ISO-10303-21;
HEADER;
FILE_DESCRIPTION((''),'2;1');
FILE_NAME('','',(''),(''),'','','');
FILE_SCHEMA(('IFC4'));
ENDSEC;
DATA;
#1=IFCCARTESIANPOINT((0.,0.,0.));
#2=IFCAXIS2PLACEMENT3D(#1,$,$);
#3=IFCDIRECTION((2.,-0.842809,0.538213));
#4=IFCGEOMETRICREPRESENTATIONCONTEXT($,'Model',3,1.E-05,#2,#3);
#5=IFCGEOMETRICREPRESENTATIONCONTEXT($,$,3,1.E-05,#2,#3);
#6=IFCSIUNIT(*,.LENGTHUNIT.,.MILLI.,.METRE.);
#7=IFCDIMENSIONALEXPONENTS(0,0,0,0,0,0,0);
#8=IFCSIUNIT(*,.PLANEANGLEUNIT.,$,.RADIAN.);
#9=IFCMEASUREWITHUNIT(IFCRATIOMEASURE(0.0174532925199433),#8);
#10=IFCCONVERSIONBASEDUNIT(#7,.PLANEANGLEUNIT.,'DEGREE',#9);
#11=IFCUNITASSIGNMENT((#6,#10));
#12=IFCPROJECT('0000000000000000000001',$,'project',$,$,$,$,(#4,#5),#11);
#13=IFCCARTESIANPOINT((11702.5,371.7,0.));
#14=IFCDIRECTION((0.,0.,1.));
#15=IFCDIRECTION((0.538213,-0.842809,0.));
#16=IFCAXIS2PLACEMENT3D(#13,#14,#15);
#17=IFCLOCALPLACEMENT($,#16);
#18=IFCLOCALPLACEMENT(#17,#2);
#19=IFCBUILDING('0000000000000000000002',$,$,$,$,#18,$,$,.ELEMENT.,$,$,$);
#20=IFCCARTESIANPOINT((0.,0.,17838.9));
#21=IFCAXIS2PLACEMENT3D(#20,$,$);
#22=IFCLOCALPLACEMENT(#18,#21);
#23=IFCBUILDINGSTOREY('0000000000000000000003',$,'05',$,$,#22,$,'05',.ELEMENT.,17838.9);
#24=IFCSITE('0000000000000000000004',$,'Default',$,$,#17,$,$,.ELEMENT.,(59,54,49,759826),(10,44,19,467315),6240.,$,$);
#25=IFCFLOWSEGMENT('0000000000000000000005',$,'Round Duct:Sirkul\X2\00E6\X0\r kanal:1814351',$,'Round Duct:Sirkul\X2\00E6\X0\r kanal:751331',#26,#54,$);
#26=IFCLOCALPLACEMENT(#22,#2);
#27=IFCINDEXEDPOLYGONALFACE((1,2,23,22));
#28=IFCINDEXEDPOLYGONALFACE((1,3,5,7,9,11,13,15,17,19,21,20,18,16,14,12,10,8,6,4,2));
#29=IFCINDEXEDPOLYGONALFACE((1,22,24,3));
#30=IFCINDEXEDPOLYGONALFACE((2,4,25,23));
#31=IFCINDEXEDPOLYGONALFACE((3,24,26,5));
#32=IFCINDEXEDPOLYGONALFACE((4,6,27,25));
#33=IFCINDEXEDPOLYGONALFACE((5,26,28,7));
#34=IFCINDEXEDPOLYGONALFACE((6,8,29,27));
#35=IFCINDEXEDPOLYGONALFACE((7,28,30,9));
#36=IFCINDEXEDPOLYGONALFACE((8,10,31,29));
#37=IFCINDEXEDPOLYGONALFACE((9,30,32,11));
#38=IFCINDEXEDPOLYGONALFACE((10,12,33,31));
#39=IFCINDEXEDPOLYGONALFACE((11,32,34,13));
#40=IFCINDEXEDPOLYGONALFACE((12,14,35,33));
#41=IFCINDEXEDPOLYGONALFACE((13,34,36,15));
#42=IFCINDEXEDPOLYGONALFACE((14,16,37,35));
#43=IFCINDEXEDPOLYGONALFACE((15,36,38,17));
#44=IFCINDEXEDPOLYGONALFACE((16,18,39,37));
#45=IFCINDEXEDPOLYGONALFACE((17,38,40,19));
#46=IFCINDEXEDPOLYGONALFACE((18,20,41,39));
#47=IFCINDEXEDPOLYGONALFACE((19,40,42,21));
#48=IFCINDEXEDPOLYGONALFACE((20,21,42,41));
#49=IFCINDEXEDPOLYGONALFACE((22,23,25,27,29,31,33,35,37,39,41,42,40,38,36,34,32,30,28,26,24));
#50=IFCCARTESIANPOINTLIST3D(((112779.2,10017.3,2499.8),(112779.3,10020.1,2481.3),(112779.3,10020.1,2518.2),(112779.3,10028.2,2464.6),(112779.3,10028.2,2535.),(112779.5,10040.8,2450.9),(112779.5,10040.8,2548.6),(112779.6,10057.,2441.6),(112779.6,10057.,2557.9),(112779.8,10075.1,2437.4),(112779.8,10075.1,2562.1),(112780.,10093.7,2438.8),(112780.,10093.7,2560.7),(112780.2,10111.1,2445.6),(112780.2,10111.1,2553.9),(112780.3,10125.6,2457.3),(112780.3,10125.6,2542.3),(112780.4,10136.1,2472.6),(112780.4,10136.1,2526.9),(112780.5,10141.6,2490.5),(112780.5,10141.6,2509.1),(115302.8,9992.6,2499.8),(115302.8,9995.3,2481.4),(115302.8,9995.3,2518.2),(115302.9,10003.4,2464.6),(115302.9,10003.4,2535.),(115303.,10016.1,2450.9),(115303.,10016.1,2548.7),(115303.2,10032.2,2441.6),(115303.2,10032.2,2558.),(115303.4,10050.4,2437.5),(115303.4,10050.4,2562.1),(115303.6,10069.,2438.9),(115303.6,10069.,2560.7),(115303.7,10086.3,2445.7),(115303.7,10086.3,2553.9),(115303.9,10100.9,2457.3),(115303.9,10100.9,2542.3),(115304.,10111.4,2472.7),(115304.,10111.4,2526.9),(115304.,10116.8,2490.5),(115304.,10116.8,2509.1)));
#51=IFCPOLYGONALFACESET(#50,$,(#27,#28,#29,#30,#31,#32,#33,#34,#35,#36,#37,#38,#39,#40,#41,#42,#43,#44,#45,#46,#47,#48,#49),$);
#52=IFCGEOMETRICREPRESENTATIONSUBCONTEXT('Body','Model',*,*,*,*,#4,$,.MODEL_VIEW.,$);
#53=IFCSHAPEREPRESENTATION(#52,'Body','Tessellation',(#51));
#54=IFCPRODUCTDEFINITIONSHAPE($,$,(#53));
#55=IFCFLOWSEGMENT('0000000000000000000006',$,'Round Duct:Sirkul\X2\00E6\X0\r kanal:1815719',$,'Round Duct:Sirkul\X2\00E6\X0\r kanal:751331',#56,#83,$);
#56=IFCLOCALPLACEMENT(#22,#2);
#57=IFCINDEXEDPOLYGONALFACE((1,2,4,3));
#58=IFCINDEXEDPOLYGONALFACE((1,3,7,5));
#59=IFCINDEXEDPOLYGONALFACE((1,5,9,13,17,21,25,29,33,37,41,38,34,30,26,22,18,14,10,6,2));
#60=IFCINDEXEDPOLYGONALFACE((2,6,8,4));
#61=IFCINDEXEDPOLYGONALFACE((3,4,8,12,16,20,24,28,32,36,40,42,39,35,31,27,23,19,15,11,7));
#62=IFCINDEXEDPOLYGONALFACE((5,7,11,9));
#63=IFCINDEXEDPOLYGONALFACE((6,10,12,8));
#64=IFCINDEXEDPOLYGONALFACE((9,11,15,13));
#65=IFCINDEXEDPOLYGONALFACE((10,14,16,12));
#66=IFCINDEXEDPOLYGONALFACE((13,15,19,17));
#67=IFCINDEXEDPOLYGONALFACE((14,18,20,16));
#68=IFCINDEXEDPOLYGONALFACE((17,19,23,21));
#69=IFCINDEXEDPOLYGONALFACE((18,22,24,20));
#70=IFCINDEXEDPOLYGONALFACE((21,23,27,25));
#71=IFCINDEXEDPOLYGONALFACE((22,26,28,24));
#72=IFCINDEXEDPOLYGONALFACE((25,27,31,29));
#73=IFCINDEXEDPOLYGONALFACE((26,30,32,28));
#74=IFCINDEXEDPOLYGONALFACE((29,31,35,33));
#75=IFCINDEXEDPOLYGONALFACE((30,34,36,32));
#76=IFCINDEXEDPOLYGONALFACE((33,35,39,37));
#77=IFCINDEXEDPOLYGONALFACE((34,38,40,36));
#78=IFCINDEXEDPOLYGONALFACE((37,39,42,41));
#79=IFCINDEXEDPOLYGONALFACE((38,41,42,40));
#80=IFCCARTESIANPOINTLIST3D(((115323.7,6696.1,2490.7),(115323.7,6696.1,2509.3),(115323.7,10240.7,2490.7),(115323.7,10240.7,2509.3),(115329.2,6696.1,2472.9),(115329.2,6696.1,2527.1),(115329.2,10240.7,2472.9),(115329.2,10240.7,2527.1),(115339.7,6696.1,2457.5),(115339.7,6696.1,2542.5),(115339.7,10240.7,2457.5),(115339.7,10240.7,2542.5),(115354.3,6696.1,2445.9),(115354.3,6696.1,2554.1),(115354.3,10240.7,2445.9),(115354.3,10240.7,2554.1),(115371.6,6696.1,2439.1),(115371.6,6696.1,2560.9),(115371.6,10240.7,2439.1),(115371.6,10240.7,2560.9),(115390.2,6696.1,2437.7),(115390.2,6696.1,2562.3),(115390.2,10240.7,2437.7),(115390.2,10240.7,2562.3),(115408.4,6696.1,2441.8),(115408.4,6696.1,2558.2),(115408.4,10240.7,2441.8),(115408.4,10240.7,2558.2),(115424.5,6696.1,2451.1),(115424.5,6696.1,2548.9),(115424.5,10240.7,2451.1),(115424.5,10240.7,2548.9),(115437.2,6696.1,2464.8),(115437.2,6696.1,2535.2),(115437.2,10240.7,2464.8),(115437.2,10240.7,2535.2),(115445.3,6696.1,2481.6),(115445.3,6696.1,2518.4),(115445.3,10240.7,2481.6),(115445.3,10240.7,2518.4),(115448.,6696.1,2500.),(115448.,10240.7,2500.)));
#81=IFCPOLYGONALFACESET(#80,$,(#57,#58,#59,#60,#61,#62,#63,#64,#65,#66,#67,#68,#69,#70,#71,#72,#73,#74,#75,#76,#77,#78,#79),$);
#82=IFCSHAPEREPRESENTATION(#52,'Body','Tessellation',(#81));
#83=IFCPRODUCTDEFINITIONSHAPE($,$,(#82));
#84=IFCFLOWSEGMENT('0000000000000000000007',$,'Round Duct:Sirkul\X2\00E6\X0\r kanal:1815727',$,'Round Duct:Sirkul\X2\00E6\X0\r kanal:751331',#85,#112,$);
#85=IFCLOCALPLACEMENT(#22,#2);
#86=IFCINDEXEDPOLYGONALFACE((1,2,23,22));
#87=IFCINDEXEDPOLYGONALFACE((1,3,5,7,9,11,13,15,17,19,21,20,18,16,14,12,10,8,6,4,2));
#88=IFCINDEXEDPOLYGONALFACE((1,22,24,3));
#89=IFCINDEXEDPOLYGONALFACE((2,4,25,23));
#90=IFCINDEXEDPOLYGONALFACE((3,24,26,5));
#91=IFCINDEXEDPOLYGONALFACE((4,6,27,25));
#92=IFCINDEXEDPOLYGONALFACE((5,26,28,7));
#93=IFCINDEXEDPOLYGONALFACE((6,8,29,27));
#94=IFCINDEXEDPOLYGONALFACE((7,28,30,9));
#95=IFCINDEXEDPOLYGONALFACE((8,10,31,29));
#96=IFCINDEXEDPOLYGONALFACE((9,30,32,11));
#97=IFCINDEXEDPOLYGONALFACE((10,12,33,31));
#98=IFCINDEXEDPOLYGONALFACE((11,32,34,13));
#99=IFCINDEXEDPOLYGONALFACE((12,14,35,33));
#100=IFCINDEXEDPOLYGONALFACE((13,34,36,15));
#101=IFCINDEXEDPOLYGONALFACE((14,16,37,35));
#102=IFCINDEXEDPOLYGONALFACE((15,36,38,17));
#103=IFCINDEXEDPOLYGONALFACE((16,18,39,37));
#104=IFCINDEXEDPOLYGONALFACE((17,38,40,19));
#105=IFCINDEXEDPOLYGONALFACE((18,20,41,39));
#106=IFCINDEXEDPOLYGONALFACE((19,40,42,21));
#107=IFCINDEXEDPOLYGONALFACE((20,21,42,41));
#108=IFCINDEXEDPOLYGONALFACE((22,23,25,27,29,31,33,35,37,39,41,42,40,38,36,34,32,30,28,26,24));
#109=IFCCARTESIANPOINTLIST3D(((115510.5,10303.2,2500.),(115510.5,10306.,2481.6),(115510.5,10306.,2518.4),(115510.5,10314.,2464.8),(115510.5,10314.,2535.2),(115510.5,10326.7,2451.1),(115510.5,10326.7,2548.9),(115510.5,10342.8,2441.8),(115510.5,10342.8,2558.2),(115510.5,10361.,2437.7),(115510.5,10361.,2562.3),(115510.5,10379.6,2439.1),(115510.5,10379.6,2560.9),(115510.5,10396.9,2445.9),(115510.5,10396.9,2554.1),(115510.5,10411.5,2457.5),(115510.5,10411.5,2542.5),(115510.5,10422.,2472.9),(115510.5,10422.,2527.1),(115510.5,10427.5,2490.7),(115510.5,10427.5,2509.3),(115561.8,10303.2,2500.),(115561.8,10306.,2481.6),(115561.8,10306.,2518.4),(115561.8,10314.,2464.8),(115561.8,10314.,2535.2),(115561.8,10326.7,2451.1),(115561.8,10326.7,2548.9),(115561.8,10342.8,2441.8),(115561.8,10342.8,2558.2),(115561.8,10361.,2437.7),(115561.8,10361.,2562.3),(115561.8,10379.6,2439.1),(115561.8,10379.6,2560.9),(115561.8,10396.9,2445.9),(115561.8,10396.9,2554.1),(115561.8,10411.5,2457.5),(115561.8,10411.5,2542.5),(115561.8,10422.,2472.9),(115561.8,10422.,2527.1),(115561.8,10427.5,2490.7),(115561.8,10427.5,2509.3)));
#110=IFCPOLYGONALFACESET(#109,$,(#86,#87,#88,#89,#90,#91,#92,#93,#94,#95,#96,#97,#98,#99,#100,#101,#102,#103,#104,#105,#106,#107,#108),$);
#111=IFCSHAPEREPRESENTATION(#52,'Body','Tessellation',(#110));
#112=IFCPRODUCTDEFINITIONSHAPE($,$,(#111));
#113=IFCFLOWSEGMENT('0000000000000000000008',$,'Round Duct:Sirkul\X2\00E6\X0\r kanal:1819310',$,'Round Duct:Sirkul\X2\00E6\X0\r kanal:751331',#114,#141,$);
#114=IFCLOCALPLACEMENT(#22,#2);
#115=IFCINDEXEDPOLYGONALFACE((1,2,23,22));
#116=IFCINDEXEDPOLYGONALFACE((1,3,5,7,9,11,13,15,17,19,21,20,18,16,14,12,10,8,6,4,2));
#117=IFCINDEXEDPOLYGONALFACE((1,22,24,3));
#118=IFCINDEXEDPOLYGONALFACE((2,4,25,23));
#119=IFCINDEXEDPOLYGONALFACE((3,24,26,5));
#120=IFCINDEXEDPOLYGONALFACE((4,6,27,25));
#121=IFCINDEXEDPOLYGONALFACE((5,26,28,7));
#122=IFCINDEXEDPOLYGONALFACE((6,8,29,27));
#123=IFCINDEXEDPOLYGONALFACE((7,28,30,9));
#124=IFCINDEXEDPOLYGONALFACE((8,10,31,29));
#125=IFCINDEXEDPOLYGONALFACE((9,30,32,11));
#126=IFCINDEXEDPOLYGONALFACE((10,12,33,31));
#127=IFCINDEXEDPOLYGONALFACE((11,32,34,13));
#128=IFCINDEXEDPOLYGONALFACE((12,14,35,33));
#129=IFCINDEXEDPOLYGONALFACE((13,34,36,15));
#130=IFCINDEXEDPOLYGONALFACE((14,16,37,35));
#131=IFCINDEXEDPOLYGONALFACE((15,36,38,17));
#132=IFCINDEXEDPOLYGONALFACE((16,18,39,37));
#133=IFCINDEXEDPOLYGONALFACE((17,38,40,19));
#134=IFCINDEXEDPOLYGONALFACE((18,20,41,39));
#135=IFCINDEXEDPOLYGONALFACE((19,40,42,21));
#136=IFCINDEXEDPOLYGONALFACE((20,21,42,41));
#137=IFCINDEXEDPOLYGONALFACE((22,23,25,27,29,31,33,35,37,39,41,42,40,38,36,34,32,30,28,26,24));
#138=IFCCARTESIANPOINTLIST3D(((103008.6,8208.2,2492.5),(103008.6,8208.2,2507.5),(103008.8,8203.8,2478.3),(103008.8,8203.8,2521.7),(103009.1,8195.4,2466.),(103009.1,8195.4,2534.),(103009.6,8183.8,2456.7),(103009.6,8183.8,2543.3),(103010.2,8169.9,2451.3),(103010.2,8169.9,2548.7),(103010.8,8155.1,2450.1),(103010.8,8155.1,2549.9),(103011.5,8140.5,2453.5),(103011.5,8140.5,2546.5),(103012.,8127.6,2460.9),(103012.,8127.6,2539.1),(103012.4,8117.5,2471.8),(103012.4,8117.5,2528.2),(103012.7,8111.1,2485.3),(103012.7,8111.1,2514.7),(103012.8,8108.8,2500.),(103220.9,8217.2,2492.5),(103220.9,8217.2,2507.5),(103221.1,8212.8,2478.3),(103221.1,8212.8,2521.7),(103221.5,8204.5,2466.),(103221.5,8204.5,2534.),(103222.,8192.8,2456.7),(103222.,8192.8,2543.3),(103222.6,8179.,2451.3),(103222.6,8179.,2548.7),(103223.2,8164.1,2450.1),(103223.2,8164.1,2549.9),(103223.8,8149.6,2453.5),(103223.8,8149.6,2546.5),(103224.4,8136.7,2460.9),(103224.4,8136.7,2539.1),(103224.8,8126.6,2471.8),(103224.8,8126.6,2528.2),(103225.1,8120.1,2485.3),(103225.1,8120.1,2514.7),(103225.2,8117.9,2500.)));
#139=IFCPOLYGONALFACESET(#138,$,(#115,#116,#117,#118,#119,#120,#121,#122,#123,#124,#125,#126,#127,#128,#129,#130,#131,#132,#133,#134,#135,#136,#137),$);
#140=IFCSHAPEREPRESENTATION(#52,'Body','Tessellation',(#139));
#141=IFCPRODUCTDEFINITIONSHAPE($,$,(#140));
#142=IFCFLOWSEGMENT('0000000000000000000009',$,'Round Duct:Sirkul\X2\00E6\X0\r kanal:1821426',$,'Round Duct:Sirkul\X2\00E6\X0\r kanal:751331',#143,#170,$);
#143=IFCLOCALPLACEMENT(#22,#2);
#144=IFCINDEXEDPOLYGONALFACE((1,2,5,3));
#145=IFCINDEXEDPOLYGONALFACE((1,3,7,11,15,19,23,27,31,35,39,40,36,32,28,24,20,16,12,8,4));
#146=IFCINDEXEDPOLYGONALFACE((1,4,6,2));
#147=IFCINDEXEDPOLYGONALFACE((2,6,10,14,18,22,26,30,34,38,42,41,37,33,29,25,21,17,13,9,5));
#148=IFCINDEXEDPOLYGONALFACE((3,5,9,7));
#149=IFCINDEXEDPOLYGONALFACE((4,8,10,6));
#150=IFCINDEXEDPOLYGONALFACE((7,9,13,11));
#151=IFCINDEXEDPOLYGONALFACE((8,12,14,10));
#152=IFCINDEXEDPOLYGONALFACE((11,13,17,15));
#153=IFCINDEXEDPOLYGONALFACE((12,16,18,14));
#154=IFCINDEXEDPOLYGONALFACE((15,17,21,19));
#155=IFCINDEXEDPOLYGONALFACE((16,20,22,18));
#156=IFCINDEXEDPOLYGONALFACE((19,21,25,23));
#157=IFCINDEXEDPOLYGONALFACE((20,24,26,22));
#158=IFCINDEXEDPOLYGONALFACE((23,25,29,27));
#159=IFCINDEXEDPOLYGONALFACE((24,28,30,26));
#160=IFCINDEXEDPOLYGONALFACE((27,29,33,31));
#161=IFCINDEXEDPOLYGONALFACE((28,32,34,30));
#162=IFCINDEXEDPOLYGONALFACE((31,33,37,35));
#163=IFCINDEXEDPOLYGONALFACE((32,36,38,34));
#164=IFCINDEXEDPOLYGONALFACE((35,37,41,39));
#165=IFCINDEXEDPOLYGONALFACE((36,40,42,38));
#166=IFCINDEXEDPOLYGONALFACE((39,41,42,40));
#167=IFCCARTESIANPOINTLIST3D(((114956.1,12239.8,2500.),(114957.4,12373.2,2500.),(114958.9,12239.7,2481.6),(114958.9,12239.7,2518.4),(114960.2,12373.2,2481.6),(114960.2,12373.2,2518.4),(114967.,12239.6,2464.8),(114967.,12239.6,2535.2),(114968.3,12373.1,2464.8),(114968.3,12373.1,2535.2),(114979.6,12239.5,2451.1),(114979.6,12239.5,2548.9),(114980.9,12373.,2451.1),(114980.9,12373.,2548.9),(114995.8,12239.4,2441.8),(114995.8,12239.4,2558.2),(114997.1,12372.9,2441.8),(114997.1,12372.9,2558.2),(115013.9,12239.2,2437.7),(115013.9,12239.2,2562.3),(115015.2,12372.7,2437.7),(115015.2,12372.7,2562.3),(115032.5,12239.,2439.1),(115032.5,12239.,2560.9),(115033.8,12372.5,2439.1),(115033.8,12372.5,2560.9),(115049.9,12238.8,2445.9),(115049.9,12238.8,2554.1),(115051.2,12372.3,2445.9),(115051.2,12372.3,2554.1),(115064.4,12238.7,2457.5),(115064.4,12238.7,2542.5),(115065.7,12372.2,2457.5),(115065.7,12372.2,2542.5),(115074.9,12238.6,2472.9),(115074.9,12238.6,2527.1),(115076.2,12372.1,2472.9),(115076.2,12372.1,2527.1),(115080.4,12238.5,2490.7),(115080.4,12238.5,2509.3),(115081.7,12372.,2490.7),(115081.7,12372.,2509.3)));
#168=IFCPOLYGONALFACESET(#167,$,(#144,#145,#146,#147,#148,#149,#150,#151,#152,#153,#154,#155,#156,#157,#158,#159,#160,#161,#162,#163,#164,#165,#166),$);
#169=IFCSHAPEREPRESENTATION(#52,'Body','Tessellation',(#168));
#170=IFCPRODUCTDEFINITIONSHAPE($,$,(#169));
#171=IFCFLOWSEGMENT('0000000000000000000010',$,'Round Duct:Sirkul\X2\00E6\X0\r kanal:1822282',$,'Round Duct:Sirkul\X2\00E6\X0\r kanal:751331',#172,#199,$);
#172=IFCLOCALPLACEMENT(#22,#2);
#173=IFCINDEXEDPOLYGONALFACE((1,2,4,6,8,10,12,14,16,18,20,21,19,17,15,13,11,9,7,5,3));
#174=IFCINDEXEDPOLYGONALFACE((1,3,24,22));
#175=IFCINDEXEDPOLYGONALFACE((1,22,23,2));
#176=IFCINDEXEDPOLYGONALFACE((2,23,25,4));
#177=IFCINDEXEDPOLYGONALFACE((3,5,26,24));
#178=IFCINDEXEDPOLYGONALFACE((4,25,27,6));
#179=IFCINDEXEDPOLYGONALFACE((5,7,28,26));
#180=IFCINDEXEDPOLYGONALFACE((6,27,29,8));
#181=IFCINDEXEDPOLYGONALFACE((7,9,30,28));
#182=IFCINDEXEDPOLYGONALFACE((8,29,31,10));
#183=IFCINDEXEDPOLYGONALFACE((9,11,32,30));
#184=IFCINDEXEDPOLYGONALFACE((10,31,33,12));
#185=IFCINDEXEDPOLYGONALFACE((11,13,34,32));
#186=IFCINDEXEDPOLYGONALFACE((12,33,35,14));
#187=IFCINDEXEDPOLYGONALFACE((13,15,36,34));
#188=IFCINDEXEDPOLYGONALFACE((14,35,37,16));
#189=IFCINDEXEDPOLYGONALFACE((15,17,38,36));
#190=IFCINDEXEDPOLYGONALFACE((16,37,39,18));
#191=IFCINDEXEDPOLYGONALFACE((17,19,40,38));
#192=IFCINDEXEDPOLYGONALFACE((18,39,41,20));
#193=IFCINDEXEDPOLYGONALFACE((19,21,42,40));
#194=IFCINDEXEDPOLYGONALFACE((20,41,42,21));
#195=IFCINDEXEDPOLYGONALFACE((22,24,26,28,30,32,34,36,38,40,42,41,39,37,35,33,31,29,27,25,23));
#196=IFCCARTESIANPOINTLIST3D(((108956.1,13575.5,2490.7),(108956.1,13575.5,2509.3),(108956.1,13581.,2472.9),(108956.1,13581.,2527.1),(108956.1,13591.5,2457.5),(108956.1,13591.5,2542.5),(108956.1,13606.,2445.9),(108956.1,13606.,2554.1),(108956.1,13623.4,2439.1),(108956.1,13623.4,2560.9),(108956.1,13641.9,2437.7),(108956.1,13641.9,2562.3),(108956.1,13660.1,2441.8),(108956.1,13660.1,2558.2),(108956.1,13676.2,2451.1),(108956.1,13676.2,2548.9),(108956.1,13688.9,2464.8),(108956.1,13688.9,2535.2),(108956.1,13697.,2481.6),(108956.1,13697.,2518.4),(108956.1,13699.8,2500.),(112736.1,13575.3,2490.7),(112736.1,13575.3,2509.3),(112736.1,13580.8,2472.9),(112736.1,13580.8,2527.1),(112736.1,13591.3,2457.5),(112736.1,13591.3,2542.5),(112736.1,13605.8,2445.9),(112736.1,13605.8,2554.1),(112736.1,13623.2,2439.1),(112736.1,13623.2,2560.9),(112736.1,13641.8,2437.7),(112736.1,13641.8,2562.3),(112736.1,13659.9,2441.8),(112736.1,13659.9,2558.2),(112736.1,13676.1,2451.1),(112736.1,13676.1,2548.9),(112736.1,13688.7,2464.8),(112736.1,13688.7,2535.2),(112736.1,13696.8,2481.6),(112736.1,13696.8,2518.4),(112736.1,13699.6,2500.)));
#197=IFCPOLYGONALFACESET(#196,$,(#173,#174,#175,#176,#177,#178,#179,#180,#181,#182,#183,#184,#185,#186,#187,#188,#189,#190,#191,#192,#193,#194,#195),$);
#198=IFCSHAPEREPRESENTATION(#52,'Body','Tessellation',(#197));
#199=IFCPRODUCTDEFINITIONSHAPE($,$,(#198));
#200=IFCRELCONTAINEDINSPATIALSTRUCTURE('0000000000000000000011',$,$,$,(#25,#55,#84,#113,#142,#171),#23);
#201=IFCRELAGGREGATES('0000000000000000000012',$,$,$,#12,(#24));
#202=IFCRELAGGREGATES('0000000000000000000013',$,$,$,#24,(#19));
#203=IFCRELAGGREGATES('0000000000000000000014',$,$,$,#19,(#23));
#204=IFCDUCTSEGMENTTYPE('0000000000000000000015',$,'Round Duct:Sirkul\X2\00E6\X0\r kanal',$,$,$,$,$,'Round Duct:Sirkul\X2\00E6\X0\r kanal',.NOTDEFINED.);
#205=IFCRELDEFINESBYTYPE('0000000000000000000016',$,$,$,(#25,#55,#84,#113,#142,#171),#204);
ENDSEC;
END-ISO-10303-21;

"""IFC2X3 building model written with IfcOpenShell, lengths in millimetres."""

from ifc_helpers import new_model, entity, si_unit, converted_unit, direction, frame, origin, origin_2d_with_axis, place, context, subcontext, project, spatial, circle, extrude, type_object, element, save


model = new_model("IFC2X3")

# Units and contexts
model_context = context("Model", 3, precision=1e-05, world=origin(), true_north=direction((2.0, -0.842809, 0.538213)))
context_of_model = context(None, 3, precision=1e-05, world=origin(), true_north=direction((2.0, -0.842809, 0.538213)))
body_context = subcontext(model_context, "Body", "Model", "MODEL_VIEW")
ifc_project = project(units=[si_unit("LENGTHUNIT", "METRE", prefix="MILLI"), converted_unit("PLANEANGLEUNIT", "DEGREE", entity("IfcRatioMeasure", 0.0174532925199433), si_unit("PLANEANGLEUNIT", "RADIAN"), dimensions=[0, 0, 0, 0, 0, 0, 0])], contexts=[model_context, context_of_model])

# Site, building, storey
site_placement = place(None, frame((11702.5, 371.7, 0.0), z_axis=(0.0, 0.0, 1.0), x_axis=(0.538213, -0.842809, 0.0)))
site = spatial("IfcSite", under=ifc_project, at=site_placement, Name="Default", CompositionType="ELEMENT", RefLatitude=(59, 54, 49, 759826), RefLongitude=(10, 44, 19, 467315), RefElevation=6240.0)
building_placement = place(site_placement, origin())
building = spatial("IfcBuilding", under=site, at=building_placement, CompositionType="ELEMENT")
storey_placement = place(building_placement, frame((0.0, 0.0, 17838.9)))
storey = spatial("IfcBuildingStorey", under=building, at=storey_placement, Name="05", LongName="05", CompositionType="ELEMENT", Elevation=17838.9)

# Flow segments
duct_segment_type = type_object("IfcDuctSegmentType", Name="Round Duct:Sirkulær kanal", ElementType="Round Duct:Sirkulær kanal", PredefinedType="NOTDEFINED")
flow_segment_1_placement = place(storey_placement, origin())
element("IfcFlowSegment", 1, at=flow_segment_1_placement, inside=storey, type_object=duct_segment_type, Name="Round Duct:Sirkulær kanal:1814351", ObjectType="Round Duct:Sirkulær kanal:751331", context=body_context, shape_type="SweptSolid", body=[
    extrude(circle(Radius=62.5, at=origin_2d_with_axis()), frame((115303.4, 10055.1, 2499.8), z_axis=(-0.999952, 0.00981, -0.000017), x_axis=(-0.00981, -0.999952, 0.0)), (0.0, 0.0, 1.0), 2523.7),
])
flow_segment_2_placement = place(storey_placement, origin())
element("IfcFlowSegment", 2, at=flow_segment_2_placement, inside=storey, type_object=duct_segment_type, Name="Round Duct:Sirkulær kanal:1815719", ObjectType="Round Duct:Sirkulær kanal:751331", context=body_context, shape_type="SweptSolid", body=[
    extrude(circle(Radius=62.5, at=origin_2d_with_axis()), frame((115385.5, 6696.1, 2500.0), z_axis=(0.0, 1.0, 0.0), x_axis=(1.0, 0.0, 0.0)), (0.0, 0.0, 1.0), 3544.6),
])
flow_segment_3_placement = place(storey_placement, origin())
element("IfcFlowSegment", 3, at=flow_segment_3_placement, inside=storey, type_object=duct_segment_type, Name="Round Duct:Sirkulær kanal:1815727", ObjectType="Round Duct:Sirkulær kanal:751331", context=body_context, shape_type="SweptSolid", body=[
    extrude(circle(Radius=62.5, at=origin_2d_with_axis()), frame((115510.5, 10365.7, 2500.0), z_axis=(1.0, 0.0, 0.0), x_axis=(0.0, -1.0, 0.0)), (0.0, 0.0, 1.0), 51.2),
])
flow_segment_4_placement = place(storey_placement, origin())
element("IfcFlowSegment", 4, at=flow_segment_4_placement, inside=storey, type_object=duct_segment_type, Name="Round Duct:Sirkulær kanal:1819310", ObjectType="Round Duct:Sirkulær kanal:751331", context=body_context, shape_type="SweptSolid", body=[
    extrude(circle(Radius=50.0, at=origin_2d_with_axis()), frame((103010.7, 8158.8, 2500.0), z_axis=(0.999095, 0.042537, 0.0), x_axis=(0.042537, -0.999095, 0.0)), (0.0, 0.0, 1.0), 212.5),
])
flow_segment_5_placement = place(storey_placement, origin())
element("IfcFlowSegment", 5, at=flow_segment_5_placement, inside=storey, type_object=duct_segment_type, Name="Round Duct:Sirkulær kanal:1821426", ObjectType="Round Duct:Sirkulær kanal:751331", context=body_context, shape_type="SweptSolid", body=[
    extrude(circle(Radius=62.5, at=origin_2d_with_axis()), frame((115018.6, 12239.1, 2500.0), z_axis=(0.00981, 0.999952, 0.0), x_axis=(-0.999952, 0.00981, 0.0)), (0.0, 0.0, 1.0), 133.5),
])
flow_segment_6_placement = place(storey_placement, origin())
element("IfcFlowSegment", 6, at=flow_segment_6_placement, inside=storey, type_object=duct_segment_type, Name="Round Duct:Sirkulær kanal:1822282", ObjectType="Round Duct:Sirkulær kanal:751331", context=body_context, shape_type="SweptSolid", body=[
    extrude(circle(Radius=62.5, at=origin_2d_with_axis()), frame((108956.1, 13637.3, 2500.0), z_axis=(1.0, -0.000048, 0.0), x_axis=(0.000048, 1.0, 0.0)), (0.0, 0.0, 1.0), 3780.0),
])

save(model, "model.ifc")
